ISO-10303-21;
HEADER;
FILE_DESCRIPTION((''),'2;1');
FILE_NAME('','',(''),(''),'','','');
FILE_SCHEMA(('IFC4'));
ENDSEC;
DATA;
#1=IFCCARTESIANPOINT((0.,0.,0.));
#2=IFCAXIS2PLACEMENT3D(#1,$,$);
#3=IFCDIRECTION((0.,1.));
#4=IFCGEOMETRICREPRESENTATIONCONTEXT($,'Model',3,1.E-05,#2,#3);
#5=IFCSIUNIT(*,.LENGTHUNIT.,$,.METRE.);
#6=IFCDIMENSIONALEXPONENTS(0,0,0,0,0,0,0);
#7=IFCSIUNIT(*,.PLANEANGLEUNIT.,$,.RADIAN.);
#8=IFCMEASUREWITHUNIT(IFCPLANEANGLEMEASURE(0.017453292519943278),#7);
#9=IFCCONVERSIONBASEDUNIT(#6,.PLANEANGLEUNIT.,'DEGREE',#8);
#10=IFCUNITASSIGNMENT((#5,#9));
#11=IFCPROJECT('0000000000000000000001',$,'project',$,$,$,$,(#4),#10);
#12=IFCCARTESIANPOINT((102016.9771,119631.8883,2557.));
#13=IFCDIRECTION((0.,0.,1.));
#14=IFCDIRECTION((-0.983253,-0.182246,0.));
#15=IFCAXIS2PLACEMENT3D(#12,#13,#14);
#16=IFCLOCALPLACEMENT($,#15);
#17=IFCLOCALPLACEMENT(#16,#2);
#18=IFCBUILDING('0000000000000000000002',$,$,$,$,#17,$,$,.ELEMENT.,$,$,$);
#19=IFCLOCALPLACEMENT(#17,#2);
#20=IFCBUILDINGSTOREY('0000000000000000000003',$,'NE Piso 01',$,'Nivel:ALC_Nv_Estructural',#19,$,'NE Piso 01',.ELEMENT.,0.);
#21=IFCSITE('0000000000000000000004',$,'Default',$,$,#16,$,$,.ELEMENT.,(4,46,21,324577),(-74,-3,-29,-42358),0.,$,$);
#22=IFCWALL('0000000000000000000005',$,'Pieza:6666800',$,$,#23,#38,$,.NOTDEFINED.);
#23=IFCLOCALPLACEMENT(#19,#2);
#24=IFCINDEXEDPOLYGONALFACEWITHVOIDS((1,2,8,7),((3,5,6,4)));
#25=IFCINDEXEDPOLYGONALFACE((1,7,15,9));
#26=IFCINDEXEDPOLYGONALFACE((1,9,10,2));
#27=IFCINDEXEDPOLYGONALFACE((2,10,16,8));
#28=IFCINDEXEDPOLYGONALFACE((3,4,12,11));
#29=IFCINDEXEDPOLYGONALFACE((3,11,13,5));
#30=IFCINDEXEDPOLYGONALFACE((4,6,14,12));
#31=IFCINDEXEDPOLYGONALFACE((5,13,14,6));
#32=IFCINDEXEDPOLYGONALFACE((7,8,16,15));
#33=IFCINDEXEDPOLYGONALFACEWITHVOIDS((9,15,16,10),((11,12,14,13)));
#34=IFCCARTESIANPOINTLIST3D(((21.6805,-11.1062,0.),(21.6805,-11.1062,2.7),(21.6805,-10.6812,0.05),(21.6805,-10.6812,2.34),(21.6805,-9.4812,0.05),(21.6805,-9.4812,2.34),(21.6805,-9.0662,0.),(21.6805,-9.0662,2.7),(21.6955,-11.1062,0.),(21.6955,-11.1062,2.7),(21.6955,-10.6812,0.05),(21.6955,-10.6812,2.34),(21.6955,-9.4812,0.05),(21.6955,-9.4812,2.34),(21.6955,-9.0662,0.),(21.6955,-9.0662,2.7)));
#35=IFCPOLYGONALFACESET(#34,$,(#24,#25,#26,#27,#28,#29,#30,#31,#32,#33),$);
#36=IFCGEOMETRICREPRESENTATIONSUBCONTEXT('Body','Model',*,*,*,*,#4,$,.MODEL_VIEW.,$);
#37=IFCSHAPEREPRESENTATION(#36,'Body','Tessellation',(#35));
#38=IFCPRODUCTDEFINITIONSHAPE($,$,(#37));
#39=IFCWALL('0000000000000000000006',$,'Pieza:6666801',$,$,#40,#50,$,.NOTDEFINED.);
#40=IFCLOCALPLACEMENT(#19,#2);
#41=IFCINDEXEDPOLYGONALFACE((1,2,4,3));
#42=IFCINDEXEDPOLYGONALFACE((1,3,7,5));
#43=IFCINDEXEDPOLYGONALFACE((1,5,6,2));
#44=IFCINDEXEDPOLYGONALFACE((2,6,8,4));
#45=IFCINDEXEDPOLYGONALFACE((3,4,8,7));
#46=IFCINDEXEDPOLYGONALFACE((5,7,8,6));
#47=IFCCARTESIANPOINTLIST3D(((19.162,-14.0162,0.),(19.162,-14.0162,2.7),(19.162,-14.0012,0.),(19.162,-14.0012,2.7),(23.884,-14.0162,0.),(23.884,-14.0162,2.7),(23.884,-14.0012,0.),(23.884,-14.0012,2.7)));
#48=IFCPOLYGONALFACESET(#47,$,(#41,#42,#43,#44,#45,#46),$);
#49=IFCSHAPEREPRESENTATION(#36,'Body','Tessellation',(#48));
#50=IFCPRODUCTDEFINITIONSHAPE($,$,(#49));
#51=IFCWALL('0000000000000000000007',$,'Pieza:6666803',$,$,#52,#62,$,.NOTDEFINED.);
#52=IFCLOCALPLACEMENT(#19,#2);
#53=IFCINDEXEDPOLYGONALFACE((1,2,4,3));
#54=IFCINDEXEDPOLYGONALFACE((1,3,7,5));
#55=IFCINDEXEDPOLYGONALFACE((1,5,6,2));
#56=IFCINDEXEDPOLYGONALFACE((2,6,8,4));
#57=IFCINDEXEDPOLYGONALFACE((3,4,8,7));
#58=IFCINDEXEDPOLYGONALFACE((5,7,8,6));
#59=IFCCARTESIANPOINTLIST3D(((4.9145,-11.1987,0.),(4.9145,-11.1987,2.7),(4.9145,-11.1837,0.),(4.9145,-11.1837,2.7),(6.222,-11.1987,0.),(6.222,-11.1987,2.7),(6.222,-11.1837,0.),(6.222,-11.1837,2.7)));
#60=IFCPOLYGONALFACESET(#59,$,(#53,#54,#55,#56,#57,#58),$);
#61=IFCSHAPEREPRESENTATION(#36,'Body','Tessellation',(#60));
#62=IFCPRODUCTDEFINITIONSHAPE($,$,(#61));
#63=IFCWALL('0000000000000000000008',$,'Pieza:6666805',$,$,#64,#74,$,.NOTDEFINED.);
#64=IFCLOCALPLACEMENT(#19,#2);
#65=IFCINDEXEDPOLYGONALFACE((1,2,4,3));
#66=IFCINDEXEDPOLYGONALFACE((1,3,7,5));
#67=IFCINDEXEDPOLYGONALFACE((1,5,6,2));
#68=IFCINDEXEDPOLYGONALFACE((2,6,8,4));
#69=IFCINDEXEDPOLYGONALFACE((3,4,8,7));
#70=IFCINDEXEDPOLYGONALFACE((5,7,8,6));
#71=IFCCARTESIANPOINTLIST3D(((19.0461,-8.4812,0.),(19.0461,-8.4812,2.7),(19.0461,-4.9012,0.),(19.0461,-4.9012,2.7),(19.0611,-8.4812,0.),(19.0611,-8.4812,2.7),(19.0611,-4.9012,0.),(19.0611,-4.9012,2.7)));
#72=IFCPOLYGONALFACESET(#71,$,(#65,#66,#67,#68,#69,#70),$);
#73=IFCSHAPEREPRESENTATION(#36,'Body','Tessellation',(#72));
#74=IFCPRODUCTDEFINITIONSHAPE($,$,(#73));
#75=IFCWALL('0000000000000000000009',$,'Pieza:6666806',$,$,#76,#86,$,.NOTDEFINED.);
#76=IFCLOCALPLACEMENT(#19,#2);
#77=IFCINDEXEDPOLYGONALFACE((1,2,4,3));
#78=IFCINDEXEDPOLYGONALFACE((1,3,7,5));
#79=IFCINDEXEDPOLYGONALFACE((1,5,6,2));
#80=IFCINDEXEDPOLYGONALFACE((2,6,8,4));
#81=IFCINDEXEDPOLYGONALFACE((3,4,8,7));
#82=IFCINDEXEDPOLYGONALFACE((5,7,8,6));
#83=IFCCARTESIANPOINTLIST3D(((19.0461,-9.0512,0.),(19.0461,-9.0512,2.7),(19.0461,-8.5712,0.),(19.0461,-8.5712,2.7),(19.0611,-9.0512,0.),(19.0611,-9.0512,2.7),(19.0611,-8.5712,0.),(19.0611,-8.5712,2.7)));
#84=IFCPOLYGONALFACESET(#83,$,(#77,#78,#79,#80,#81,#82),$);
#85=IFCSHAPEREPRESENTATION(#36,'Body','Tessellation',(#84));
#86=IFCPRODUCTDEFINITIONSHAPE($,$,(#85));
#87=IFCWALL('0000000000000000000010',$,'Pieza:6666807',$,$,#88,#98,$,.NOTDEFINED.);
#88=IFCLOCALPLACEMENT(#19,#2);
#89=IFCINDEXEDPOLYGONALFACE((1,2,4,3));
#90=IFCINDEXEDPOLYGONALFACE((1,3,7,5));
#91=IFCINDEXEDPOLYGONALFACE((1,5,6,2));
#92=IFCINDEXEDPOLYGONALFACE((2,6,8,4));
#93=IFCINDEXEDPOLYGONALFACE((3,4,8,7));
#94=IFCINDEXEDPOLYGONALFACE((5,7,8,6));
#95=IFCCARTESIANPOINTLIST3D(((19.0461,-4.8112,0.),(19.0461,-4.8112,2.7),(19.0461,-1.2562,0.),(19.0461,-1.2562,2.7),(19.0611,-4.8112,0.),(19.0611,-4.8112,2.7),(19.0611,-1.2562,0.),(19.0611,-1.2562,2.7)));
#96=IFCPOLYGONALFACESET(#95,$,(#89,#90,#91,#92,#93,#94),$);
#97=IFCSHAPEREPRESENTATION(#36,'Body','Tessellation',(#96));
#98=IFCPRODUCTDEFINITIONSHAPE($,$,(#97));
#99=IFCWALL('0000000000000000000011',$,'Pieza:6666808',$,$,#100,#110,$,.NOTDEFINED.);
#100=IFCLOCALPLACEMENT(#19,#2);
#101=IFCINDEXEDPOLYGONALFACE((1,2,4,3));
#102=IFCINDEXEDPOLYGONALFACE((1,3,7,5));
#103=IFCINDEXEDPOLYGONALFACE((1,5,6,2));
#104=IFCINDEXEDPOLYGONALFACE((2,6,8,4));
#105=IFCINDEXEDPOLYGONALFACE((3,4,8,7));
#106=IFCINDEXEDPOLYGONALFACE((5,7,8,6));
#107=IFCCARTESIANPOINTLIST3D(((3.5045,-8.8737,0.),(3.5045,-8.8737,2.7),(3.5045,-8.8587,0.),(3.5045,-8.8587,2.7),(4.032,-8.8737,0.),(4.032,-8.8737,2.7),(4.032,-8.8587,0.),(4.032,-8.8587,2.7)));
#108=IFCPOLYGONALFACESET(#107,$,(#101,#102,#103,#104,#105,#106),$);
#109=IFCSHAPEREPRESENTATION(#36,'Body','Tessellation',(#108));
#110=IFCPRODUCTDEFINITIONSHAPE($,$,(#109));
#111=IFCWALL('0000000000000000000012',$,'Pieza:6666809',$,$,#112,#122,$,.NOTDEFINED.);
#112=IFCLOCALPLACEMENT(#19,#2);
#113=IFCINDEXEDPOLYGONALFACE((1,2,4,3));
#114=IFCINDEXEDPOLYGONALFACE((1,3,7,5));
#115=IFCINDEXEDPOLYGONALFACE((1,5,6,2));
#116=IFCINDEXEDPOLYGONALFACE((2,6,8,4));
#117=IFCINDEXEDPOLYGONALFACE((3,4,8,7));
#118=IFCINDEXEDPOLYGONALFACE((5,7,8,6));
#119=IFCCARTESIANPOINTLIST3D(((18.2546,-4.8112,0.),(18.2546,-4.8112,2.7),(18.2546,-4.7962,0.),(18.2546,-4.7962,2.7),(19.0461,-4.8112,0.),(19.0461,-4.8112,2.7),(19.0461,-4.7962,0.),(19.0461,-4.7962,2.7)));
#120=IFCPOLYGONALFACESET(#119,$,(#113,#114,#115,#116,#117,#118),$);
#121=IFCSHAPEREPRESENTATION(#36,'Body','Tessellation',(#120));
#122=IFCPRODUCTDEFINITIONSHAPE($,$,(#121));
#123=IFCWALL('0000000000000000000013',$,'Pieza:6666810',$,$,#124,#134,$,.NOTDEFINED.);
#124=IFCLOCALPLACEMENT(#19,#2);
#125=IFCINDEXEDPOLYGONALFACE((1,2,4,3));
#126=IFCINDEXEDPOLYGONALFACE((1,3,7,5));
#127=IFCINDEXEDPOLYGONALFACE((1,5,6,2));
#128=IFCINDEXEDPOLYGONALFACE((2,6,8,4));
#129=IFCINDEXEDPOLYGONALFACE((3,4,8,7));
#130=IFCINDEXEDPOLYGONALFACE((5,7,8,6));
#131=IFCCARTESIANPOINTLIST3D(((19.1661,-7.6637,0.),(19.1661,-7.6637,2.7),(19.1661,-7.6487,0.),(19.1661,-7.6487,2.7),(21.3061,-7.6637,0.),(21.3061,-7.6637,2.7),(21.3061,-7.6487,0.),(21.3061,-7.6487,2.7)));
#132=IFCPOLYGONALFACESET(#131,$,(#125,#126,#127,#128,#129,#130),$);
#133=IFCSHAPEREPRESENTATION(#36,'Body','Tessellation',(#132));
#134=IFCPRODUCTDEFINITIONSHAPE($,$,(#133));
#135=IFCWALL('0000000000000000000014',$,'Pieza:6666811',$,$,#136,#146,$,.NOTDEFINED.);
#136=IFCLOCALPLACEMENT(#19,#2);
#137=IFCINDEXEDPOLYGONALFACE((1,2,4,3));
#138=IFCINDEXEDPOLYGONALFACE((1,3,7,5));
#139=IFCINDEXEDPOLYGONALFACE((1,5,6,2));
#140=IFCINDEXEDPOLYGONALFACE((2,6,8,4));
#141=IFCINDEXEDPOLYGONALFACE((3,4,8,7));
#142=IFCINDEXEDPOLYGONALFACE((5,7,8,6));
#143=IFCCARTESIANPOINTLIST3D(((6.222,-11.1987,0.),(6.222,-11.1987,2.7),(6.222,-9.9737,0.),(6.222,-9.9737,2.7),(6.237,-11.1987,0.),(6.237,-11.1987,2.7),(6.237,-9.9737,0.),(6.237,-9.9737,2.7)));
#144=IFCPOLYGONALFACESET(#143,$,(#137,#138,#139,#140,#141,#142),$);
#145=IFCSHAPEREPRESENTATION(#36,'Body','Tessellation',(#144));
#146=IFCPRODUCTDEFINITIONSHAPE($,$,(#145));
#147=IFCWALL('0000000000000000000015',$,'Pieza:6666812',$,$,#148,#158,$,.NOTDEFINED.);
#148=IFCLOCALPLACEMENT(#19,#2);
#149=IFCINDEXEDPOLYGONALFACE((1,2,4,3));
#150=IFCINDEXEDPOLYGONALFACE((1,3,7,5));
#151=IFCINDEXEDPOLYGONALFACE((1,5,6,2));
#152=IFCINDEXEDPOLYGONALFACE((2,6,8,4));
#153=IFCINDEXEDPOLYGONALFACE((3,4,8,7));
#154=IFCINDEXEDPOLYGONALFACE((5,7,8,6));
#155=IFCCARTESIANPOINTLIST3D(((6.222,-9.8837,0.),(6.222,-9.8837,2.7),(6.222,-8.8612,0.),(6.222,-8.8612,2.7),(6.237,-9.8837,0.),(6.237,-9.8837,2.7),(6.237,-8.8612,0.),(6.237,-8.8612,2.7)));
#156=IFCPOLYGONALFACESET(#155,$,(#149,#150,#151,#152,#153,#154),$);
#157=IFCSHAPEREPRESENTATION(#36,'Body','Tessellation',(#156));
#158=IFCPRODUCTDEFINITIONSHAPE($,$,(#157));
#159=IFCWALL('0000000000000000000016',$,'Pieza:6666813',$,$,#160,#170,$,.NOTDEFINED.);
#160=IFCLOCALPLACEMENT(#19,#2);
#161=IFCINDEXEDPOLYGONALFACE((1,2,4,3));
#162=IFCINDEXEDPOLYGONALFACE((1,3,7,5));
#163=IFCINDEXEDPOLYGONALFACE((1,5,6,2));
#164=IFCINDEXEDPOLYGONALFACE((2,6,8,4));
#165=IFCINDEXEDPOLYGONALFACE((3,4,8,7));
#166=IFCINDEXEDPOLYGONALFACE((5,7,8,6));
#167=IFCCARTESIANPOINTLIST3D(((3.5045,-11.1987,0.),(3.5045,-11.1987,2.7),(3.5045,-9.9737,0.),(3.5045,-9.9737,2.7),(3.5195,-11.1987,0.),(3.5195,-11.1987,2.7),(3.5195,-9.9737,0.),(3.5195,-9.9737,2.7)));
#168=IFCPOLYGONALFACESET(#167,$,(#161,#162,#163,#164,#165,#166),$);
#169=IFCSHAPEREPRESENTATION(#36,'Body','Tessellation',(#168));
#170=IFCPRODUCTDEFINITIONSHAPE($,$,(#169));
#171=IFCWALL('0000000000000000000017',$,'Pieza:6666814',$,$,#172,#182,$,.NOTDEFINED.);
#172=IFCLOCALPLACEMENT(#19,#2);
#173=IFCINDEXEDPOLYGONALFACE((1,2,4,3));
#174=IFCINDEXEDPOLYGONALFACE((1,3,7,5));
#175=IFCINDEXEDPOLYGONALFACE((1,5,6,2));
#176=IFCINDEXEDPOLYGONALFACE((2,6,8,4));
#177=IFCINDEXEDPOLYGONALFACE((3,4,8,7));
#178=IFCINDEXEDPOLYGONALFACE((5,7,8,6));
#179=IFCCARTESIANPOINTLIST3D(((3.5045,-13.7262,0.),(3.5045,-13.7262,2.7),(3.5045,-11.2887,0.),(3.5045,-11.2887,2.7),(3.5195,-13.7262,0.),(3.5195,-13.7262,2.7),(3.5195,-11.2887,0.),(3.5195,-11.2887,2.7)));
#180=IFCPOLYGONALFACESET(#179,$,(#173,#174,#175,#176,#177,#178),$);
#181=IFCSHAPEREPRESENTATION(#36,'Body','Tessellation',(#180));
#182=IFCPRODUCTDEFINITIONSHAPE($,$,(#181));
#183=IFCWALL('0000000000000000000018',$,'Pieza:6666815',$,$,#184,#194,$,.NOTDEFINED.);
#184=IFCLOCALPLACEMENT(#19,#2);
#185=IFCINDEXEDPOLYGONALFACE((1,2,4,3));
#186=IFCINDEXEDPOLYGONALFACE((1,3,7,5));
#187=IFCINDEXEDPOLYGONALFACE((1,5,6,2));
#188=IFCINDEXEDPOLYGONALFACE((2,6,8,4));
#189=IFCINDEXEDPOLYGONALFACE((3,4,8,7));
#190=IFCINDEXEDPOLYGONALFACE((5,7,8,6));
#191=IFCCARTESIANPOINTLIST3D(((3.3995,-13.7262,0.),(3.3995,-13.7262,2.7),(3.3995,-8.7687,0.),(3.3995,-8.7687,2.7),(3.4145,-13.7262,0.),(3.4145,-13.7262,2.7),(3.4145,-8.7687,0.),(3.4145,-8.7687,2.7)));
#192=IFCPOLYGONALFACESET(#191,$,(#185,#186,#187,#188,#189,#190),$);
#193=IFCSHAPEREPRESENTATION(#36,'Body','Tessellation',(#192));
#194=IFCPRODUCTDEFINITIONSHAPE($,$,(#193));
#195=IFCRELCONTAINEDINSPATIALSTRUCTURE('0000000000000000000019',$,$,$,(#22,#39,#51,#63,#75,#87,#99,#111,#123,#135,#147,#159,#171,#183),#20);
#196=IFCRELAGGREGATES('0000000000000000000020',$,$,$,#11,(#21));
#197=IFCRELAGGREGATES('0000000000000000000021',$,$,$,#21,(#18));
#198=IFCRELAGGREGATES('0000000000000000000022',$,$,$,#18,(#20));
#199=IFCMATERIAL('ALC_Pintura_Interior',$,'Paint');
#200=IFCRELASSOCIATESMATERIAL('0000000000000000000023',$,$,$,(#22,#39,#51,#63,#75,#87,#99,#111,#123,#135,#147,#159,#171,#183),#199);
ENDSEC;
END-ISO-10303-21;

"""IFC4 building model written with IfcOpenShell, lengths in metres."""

from ifc_helpers import new_model, entity, si_unit, converted_unit, direction, frame, frame_2d, origin, origin_2d_with_axis, place, context, subcontext, project, spatial, rectangle, extrude, boolean, material, element, save


model = new_model("IFC4")

# Units and contexts
model_context = context("Model", 3, precision=1e-05, world=origin(), true_north=direction((0.0, 1.0)))
body_context = subcontext(model_context, "Body", "Model", "MODEL_VIEW")
ifc_project = project(units=[si_unit("LENGTHUNIT", "METRE"), converted_unit("PLANEANGLEUNIT", "DEGREE", entity("IfcPlaneAngleMeasure", 0.017453292519943278), si_unit("PLANEANGLEUNIT", "RADIAN"), dimensions=[0, 0, 0, 0, 0, 0, 0])], contexts=[model_context])

# Site, building, storey
site_placement = place(None, frame((102016.9771, 119631.8883, 2557.0), z_axis=(0.0, 0.0, 1.0), x_axis=(-0.983253, -0.182246, 0.0)))
site = spatial("IfcSite", under=ifc_project, at=site_placement, Name="Default", CompositionType="ELEMENT", RefLatitude=(4, 46, 21, 324577), RefLongitude=(-74, -3, -29, -42358), RefElevation=0.0)
building_placement = place(site_placement, origin())
building = spatial("IfcBuilding", under=site, at=building_placement, CompositionType="ELEMENT")
storey_placement = place(building_placement, origin())
storey = spatial("IfcBuildingStorey", under=building, at=storey_placement, Name="NE Piso 01", ObjectType="Nivel:ALC_Nv_Estructural", LongName="NE Piso 01", CompositionType="ELEMENT", Elevation=0.0)

# Walls
ifc_material_1 = material(Name="ALC_Pintura_Interior", Category="Paint")
wall_1_placement = place(storey_placement, origin())
element("IfcWall", 1, at=wall_1_placement, inside=storey, material=ifc_material_1, Name="Pieza:6666800", PredefinedType="NOTDEFINED", context=body_context, shape_type="SweptSolid", body=[
    boolean("DIFFERENCE", extrude(rectangle(XDim=0.015, YDim=2.04, at=frame_2d((0.0, 0.0), x_axis=(1.0, 0.0))), frame((21.688, -10.0862, 0.0)), (0.0, 0.0, 1.0), 2.7), extrude(rectangle(XDim=2.29, YDim=1.2, at=frame_2d((0.0, 0.0), x_axis=(0.0, 1.0))), frame((21.6955, -10.0812, 1.195), z_axis=(1.0, 0.0, 0.0), x_axis=(0.0, -1.0, 0.0)), (0.0, 0.0, -1.0), 0.015)),
])
wall_2_placement = place(storey_placement, origin())
element("IfcWall", 2, at=wall_2_placement, inside=storey, material=ifc_material_1, Name="Pieza:6666801", PredefinedType="NOTDEFINED", context=body_context, shape_type="SweptSolid", body=[
    extrude(rectangle(XDim=0.015, YDim=4.722, at=frame_2d((0.0, 0.0), x_axis=(1.0, 0.0))), frame((21.523, -14.0087, 0.0), z_axis=(0.0, 0.0, 1.0), x_axis=(0.0, -1.0, 0.0)), (0.0, 0.0, 1.0), 2.7),
])
wall_3_placement = place(storey_placement, origin())
element("IfcWall", 3, at=wall_3_placement, inside=storey, material=ifc_material_1, Name="Pieza:6666803", PredefinedType="NOTDEFINED", context=body_context, shape_type="SweptSolid", body=[
    extrude(rectangle(XDim=0.015, YDim=1.3075, at=frame_2d((0.0, 0.0), x_axis=(1.0, 0.0))), frame((5.5683, -11.1912, 0.0), z_axis=(0.0, 0.0, 1.0), x_axis=(0.0, -1.0, 0.0)), (0.0, 0.0, 1.0), 2.7),
])
wall_4_placement = place(storey_placement, origin())
element("IfcWall", 4, at=wall_4_placement, inside=storey, material=ifc_material_1, Name="Pieza:6666805", PredefinedType="NOTDEFINED", context=body_context, shape_type="SweptSolid", body=[
    extrude(rectangle(XDim=3.58, YDim=0.015, at=frame_2d((0.0, 0.0), x_axis=(1.0, 0.0))), frame((19.0536, -6.6912, 0.0), z_axis=(0.0, 0.0, 1.0), x_axis=(0.0, -1.0, 0.0)), (0.0, 0.0, 1.0), 2.7),
])
wall_5_placement = place(storey_placement, origin())
element("IfcWall", 5, at=wall_5_placement, inside=storey, material=ifc_material_1, Name="Pieza:6666806", PredefinedType="NOTDEFINED", context=body_context, shape_type="SweptSolid", body=[
    extrude(rectangle(XDim=0.48, YDim=0.015, at=frame_2d((0.0, 0.0), x_axis=(1.0, 0.0))), frame((19.0536, -8.8112, 0.0), z_axis=(0.0, 0.0, 1.0), x_axis=(0.0, -1.0, 0.0)), (0.0, 0.0, 1.0), 2.7),
])
wall_6_placement = place(storey_placement, origin())
element("IfcWall", 6, at=wall_6_placement, inside=storey, material=ifc_material_1, Name="Pieza:6666807", PredefinedType="NOTDEFINED", context=body_context, shape_type="SweptSolid", body=[
    extrude(rectangle(XDim=3.555, YDim=0.015, at=frame_2d((0.0, 0.0), x_axis=(1.0, 0.0))), frame((19.0536, -3.0337, 0.0), z_axis=(0.0, 0.0, 1.0), x_axis=(0.0, -1.0, 0.0)), (0.0, 0.0, 1.0), 2.7),
])
wall_7_placement = place(storey_placement, origin())
element("IfcWall", 7, at=wall_7_placement, inside=storey, material=ifc_material_1, Name="Pieza:6666808", PredefinedType="NOTDEFINED", context=body_context, shape_type="SweptSolid", body=[
    extrude(rectangle(XDim=0.015, YDim=0.5275, at=frame_2d((0.0, 0.0), x_axis=(1.0, 0.0))), frame((3.7683, -8.8662, 0.0), z_axis=(0.0, 0.0, 1.0), x_axis=(0.0, -1.0, 0.0)), (0.0, 0.0, 1.0), 2.7),
])
wall_8_placement = place(storey_placement, origin())
element("IfcWall", 8, at=wall_8_placement, inside=storey, material=ifc_material_1, Name="Pieza:6666809", PredefinedType="NOTDEFINED", context=body_context, shape_type="SweptSolid", body=[
    extrude(rectangle(XDim=0.015, YDim=0.7915, at=frame_2d((0.0, 0.0), x_axis=(1.0, 0.0))), frame((18.6504, -4.8037, 0.0), z_axis=(0.0, 0.0, 1.0), x_axis=(0.0, -1.0, 0.0)), (0.0, 0.0, 1.0), 2.7),
])
wall_9_placement = place(storey_placement, origin())
element("IfcWall", 9, at=wall_9_placement, inside=storey, material=ifc_material_1, Name="Pieza:6666810", PredefinedType="NOTDEFINED", context=body_context, shape_type="SweptSolid", body=[
    extrude(rectangle(XDim=0.015, YDim=2.14, at=frame_2d((0.0, 0.0), x_axis=(1.0, 0.0))), frame((20.2361, -7.6562, 0.0), z_axis=(0.0, 0.0, 1.0), x_axis=(0.0, -1.0, 0.0)), (0.0, 0.0, 1.0), 2.7),
])
wall_10_placement = place(storey_placement, origin())
element("IfcWall", 10, at=wall_10_placement, inside=storey, material=ifc_material_1, Name="Pieza:6666811", PredefinedType="NOTDEFINED", context=body_context, shape_type="SweptSolid", body=[
    extrude(rectangle(XDim=1.225, YDim=0.015, at=origin_2d_with_axis()), frame((6.2295, -10.5862, 0.0), z_axis=(0.0, 0.0, 1.0), x_axis=(0.0, -1.0, 0.0)), (0.0, 0.0, 1.0), 2.7),
])
wall_11_placement = place(storey_placement, origin())
element("IfcWall", 11, at=wall_11_placement, inside=storey, material=ifc_material_1, Name="Pieza:6666812", PredefinedType="NOTDEFINED", context=body_context, shape_type="SweptSolid", body=[
    extrude(rectangle(XDim=1.0225, YDim=0.015, at=frame_2d((0.0, 0.0), x_axis=(1.0, 0.0))), frame((6.2295, -9.3724, 0.0), z_axis=(0.0, 0.0, 1.0), x_axis=(0.0, -1.0, 0.0)), (0.0, 0.0, 1.0), 2.7),
])
wall_12_placement = place(storey_placement, origin())
element("IfcWall", 12, at=wall_12_placement, inside=storey, material=ifc_material_1, Name="Pieza:6666813", PredefinedType="NOTDEFINED", context=body_context, shape_type="SweptSolid", body=[
    extrude(rectangle(XDim=1.225, YDim=0.015, at=frame_2d((0.0, 0.0), x_axis=(1.0, 0.0))), frame((3.512, -10.5862, 0.0), z_axis=(0.0, 0.0, 1.0), x_axis=(0.0, -1.0, 0.0)), (0.0, 0.0, 1.0), 2.7),
])
wall_13_placement = place(storey_placement, origin())
element("IfcWall", 13, at=wall_13_placement, inside=storey, material=ifc_material_1, Name="Pieza:6666814", PredefinedType="NOTDEFINED", context=body_context, shape_type="SweptSolid", body=[
    extrude(rectangle(XDim=2.4375, YDim=0.015, at=frame_2d((0.0, 0.0), x_axis=(1.0, 0.0))), frame((3.512, -12.5074, 0.0), z_axis=(0.0, 0.0, 1.0), x_axis=(0.0, -1.0, 0.0)), (0.0, 0.0, 1.0), 2.7),
])
wall_14_placement = place(storey_placement, origin())
element("IfcWall", 14, at=wall_14_placement, inside=storey, material=ifc_material_1, Name="Pieza:6666815", PredefinedType="NOTDEFINED", context=body_context, shape_type="SweptSolid", body=[
    extrude(rectangle(XDim=4.9575, YDim=0.015, at=frame_2d((0.0, 0.0), x_axis=(1.0, 0.0))), frame((3.407, -11.2474, 0.0), z_axis=(0.0, 0.0, 1.0), x_axis=(0.0, -1.0, 0.0)), (0.0, 0.0, 1.0), 2.7),
])

save(model, "model.ifc")
